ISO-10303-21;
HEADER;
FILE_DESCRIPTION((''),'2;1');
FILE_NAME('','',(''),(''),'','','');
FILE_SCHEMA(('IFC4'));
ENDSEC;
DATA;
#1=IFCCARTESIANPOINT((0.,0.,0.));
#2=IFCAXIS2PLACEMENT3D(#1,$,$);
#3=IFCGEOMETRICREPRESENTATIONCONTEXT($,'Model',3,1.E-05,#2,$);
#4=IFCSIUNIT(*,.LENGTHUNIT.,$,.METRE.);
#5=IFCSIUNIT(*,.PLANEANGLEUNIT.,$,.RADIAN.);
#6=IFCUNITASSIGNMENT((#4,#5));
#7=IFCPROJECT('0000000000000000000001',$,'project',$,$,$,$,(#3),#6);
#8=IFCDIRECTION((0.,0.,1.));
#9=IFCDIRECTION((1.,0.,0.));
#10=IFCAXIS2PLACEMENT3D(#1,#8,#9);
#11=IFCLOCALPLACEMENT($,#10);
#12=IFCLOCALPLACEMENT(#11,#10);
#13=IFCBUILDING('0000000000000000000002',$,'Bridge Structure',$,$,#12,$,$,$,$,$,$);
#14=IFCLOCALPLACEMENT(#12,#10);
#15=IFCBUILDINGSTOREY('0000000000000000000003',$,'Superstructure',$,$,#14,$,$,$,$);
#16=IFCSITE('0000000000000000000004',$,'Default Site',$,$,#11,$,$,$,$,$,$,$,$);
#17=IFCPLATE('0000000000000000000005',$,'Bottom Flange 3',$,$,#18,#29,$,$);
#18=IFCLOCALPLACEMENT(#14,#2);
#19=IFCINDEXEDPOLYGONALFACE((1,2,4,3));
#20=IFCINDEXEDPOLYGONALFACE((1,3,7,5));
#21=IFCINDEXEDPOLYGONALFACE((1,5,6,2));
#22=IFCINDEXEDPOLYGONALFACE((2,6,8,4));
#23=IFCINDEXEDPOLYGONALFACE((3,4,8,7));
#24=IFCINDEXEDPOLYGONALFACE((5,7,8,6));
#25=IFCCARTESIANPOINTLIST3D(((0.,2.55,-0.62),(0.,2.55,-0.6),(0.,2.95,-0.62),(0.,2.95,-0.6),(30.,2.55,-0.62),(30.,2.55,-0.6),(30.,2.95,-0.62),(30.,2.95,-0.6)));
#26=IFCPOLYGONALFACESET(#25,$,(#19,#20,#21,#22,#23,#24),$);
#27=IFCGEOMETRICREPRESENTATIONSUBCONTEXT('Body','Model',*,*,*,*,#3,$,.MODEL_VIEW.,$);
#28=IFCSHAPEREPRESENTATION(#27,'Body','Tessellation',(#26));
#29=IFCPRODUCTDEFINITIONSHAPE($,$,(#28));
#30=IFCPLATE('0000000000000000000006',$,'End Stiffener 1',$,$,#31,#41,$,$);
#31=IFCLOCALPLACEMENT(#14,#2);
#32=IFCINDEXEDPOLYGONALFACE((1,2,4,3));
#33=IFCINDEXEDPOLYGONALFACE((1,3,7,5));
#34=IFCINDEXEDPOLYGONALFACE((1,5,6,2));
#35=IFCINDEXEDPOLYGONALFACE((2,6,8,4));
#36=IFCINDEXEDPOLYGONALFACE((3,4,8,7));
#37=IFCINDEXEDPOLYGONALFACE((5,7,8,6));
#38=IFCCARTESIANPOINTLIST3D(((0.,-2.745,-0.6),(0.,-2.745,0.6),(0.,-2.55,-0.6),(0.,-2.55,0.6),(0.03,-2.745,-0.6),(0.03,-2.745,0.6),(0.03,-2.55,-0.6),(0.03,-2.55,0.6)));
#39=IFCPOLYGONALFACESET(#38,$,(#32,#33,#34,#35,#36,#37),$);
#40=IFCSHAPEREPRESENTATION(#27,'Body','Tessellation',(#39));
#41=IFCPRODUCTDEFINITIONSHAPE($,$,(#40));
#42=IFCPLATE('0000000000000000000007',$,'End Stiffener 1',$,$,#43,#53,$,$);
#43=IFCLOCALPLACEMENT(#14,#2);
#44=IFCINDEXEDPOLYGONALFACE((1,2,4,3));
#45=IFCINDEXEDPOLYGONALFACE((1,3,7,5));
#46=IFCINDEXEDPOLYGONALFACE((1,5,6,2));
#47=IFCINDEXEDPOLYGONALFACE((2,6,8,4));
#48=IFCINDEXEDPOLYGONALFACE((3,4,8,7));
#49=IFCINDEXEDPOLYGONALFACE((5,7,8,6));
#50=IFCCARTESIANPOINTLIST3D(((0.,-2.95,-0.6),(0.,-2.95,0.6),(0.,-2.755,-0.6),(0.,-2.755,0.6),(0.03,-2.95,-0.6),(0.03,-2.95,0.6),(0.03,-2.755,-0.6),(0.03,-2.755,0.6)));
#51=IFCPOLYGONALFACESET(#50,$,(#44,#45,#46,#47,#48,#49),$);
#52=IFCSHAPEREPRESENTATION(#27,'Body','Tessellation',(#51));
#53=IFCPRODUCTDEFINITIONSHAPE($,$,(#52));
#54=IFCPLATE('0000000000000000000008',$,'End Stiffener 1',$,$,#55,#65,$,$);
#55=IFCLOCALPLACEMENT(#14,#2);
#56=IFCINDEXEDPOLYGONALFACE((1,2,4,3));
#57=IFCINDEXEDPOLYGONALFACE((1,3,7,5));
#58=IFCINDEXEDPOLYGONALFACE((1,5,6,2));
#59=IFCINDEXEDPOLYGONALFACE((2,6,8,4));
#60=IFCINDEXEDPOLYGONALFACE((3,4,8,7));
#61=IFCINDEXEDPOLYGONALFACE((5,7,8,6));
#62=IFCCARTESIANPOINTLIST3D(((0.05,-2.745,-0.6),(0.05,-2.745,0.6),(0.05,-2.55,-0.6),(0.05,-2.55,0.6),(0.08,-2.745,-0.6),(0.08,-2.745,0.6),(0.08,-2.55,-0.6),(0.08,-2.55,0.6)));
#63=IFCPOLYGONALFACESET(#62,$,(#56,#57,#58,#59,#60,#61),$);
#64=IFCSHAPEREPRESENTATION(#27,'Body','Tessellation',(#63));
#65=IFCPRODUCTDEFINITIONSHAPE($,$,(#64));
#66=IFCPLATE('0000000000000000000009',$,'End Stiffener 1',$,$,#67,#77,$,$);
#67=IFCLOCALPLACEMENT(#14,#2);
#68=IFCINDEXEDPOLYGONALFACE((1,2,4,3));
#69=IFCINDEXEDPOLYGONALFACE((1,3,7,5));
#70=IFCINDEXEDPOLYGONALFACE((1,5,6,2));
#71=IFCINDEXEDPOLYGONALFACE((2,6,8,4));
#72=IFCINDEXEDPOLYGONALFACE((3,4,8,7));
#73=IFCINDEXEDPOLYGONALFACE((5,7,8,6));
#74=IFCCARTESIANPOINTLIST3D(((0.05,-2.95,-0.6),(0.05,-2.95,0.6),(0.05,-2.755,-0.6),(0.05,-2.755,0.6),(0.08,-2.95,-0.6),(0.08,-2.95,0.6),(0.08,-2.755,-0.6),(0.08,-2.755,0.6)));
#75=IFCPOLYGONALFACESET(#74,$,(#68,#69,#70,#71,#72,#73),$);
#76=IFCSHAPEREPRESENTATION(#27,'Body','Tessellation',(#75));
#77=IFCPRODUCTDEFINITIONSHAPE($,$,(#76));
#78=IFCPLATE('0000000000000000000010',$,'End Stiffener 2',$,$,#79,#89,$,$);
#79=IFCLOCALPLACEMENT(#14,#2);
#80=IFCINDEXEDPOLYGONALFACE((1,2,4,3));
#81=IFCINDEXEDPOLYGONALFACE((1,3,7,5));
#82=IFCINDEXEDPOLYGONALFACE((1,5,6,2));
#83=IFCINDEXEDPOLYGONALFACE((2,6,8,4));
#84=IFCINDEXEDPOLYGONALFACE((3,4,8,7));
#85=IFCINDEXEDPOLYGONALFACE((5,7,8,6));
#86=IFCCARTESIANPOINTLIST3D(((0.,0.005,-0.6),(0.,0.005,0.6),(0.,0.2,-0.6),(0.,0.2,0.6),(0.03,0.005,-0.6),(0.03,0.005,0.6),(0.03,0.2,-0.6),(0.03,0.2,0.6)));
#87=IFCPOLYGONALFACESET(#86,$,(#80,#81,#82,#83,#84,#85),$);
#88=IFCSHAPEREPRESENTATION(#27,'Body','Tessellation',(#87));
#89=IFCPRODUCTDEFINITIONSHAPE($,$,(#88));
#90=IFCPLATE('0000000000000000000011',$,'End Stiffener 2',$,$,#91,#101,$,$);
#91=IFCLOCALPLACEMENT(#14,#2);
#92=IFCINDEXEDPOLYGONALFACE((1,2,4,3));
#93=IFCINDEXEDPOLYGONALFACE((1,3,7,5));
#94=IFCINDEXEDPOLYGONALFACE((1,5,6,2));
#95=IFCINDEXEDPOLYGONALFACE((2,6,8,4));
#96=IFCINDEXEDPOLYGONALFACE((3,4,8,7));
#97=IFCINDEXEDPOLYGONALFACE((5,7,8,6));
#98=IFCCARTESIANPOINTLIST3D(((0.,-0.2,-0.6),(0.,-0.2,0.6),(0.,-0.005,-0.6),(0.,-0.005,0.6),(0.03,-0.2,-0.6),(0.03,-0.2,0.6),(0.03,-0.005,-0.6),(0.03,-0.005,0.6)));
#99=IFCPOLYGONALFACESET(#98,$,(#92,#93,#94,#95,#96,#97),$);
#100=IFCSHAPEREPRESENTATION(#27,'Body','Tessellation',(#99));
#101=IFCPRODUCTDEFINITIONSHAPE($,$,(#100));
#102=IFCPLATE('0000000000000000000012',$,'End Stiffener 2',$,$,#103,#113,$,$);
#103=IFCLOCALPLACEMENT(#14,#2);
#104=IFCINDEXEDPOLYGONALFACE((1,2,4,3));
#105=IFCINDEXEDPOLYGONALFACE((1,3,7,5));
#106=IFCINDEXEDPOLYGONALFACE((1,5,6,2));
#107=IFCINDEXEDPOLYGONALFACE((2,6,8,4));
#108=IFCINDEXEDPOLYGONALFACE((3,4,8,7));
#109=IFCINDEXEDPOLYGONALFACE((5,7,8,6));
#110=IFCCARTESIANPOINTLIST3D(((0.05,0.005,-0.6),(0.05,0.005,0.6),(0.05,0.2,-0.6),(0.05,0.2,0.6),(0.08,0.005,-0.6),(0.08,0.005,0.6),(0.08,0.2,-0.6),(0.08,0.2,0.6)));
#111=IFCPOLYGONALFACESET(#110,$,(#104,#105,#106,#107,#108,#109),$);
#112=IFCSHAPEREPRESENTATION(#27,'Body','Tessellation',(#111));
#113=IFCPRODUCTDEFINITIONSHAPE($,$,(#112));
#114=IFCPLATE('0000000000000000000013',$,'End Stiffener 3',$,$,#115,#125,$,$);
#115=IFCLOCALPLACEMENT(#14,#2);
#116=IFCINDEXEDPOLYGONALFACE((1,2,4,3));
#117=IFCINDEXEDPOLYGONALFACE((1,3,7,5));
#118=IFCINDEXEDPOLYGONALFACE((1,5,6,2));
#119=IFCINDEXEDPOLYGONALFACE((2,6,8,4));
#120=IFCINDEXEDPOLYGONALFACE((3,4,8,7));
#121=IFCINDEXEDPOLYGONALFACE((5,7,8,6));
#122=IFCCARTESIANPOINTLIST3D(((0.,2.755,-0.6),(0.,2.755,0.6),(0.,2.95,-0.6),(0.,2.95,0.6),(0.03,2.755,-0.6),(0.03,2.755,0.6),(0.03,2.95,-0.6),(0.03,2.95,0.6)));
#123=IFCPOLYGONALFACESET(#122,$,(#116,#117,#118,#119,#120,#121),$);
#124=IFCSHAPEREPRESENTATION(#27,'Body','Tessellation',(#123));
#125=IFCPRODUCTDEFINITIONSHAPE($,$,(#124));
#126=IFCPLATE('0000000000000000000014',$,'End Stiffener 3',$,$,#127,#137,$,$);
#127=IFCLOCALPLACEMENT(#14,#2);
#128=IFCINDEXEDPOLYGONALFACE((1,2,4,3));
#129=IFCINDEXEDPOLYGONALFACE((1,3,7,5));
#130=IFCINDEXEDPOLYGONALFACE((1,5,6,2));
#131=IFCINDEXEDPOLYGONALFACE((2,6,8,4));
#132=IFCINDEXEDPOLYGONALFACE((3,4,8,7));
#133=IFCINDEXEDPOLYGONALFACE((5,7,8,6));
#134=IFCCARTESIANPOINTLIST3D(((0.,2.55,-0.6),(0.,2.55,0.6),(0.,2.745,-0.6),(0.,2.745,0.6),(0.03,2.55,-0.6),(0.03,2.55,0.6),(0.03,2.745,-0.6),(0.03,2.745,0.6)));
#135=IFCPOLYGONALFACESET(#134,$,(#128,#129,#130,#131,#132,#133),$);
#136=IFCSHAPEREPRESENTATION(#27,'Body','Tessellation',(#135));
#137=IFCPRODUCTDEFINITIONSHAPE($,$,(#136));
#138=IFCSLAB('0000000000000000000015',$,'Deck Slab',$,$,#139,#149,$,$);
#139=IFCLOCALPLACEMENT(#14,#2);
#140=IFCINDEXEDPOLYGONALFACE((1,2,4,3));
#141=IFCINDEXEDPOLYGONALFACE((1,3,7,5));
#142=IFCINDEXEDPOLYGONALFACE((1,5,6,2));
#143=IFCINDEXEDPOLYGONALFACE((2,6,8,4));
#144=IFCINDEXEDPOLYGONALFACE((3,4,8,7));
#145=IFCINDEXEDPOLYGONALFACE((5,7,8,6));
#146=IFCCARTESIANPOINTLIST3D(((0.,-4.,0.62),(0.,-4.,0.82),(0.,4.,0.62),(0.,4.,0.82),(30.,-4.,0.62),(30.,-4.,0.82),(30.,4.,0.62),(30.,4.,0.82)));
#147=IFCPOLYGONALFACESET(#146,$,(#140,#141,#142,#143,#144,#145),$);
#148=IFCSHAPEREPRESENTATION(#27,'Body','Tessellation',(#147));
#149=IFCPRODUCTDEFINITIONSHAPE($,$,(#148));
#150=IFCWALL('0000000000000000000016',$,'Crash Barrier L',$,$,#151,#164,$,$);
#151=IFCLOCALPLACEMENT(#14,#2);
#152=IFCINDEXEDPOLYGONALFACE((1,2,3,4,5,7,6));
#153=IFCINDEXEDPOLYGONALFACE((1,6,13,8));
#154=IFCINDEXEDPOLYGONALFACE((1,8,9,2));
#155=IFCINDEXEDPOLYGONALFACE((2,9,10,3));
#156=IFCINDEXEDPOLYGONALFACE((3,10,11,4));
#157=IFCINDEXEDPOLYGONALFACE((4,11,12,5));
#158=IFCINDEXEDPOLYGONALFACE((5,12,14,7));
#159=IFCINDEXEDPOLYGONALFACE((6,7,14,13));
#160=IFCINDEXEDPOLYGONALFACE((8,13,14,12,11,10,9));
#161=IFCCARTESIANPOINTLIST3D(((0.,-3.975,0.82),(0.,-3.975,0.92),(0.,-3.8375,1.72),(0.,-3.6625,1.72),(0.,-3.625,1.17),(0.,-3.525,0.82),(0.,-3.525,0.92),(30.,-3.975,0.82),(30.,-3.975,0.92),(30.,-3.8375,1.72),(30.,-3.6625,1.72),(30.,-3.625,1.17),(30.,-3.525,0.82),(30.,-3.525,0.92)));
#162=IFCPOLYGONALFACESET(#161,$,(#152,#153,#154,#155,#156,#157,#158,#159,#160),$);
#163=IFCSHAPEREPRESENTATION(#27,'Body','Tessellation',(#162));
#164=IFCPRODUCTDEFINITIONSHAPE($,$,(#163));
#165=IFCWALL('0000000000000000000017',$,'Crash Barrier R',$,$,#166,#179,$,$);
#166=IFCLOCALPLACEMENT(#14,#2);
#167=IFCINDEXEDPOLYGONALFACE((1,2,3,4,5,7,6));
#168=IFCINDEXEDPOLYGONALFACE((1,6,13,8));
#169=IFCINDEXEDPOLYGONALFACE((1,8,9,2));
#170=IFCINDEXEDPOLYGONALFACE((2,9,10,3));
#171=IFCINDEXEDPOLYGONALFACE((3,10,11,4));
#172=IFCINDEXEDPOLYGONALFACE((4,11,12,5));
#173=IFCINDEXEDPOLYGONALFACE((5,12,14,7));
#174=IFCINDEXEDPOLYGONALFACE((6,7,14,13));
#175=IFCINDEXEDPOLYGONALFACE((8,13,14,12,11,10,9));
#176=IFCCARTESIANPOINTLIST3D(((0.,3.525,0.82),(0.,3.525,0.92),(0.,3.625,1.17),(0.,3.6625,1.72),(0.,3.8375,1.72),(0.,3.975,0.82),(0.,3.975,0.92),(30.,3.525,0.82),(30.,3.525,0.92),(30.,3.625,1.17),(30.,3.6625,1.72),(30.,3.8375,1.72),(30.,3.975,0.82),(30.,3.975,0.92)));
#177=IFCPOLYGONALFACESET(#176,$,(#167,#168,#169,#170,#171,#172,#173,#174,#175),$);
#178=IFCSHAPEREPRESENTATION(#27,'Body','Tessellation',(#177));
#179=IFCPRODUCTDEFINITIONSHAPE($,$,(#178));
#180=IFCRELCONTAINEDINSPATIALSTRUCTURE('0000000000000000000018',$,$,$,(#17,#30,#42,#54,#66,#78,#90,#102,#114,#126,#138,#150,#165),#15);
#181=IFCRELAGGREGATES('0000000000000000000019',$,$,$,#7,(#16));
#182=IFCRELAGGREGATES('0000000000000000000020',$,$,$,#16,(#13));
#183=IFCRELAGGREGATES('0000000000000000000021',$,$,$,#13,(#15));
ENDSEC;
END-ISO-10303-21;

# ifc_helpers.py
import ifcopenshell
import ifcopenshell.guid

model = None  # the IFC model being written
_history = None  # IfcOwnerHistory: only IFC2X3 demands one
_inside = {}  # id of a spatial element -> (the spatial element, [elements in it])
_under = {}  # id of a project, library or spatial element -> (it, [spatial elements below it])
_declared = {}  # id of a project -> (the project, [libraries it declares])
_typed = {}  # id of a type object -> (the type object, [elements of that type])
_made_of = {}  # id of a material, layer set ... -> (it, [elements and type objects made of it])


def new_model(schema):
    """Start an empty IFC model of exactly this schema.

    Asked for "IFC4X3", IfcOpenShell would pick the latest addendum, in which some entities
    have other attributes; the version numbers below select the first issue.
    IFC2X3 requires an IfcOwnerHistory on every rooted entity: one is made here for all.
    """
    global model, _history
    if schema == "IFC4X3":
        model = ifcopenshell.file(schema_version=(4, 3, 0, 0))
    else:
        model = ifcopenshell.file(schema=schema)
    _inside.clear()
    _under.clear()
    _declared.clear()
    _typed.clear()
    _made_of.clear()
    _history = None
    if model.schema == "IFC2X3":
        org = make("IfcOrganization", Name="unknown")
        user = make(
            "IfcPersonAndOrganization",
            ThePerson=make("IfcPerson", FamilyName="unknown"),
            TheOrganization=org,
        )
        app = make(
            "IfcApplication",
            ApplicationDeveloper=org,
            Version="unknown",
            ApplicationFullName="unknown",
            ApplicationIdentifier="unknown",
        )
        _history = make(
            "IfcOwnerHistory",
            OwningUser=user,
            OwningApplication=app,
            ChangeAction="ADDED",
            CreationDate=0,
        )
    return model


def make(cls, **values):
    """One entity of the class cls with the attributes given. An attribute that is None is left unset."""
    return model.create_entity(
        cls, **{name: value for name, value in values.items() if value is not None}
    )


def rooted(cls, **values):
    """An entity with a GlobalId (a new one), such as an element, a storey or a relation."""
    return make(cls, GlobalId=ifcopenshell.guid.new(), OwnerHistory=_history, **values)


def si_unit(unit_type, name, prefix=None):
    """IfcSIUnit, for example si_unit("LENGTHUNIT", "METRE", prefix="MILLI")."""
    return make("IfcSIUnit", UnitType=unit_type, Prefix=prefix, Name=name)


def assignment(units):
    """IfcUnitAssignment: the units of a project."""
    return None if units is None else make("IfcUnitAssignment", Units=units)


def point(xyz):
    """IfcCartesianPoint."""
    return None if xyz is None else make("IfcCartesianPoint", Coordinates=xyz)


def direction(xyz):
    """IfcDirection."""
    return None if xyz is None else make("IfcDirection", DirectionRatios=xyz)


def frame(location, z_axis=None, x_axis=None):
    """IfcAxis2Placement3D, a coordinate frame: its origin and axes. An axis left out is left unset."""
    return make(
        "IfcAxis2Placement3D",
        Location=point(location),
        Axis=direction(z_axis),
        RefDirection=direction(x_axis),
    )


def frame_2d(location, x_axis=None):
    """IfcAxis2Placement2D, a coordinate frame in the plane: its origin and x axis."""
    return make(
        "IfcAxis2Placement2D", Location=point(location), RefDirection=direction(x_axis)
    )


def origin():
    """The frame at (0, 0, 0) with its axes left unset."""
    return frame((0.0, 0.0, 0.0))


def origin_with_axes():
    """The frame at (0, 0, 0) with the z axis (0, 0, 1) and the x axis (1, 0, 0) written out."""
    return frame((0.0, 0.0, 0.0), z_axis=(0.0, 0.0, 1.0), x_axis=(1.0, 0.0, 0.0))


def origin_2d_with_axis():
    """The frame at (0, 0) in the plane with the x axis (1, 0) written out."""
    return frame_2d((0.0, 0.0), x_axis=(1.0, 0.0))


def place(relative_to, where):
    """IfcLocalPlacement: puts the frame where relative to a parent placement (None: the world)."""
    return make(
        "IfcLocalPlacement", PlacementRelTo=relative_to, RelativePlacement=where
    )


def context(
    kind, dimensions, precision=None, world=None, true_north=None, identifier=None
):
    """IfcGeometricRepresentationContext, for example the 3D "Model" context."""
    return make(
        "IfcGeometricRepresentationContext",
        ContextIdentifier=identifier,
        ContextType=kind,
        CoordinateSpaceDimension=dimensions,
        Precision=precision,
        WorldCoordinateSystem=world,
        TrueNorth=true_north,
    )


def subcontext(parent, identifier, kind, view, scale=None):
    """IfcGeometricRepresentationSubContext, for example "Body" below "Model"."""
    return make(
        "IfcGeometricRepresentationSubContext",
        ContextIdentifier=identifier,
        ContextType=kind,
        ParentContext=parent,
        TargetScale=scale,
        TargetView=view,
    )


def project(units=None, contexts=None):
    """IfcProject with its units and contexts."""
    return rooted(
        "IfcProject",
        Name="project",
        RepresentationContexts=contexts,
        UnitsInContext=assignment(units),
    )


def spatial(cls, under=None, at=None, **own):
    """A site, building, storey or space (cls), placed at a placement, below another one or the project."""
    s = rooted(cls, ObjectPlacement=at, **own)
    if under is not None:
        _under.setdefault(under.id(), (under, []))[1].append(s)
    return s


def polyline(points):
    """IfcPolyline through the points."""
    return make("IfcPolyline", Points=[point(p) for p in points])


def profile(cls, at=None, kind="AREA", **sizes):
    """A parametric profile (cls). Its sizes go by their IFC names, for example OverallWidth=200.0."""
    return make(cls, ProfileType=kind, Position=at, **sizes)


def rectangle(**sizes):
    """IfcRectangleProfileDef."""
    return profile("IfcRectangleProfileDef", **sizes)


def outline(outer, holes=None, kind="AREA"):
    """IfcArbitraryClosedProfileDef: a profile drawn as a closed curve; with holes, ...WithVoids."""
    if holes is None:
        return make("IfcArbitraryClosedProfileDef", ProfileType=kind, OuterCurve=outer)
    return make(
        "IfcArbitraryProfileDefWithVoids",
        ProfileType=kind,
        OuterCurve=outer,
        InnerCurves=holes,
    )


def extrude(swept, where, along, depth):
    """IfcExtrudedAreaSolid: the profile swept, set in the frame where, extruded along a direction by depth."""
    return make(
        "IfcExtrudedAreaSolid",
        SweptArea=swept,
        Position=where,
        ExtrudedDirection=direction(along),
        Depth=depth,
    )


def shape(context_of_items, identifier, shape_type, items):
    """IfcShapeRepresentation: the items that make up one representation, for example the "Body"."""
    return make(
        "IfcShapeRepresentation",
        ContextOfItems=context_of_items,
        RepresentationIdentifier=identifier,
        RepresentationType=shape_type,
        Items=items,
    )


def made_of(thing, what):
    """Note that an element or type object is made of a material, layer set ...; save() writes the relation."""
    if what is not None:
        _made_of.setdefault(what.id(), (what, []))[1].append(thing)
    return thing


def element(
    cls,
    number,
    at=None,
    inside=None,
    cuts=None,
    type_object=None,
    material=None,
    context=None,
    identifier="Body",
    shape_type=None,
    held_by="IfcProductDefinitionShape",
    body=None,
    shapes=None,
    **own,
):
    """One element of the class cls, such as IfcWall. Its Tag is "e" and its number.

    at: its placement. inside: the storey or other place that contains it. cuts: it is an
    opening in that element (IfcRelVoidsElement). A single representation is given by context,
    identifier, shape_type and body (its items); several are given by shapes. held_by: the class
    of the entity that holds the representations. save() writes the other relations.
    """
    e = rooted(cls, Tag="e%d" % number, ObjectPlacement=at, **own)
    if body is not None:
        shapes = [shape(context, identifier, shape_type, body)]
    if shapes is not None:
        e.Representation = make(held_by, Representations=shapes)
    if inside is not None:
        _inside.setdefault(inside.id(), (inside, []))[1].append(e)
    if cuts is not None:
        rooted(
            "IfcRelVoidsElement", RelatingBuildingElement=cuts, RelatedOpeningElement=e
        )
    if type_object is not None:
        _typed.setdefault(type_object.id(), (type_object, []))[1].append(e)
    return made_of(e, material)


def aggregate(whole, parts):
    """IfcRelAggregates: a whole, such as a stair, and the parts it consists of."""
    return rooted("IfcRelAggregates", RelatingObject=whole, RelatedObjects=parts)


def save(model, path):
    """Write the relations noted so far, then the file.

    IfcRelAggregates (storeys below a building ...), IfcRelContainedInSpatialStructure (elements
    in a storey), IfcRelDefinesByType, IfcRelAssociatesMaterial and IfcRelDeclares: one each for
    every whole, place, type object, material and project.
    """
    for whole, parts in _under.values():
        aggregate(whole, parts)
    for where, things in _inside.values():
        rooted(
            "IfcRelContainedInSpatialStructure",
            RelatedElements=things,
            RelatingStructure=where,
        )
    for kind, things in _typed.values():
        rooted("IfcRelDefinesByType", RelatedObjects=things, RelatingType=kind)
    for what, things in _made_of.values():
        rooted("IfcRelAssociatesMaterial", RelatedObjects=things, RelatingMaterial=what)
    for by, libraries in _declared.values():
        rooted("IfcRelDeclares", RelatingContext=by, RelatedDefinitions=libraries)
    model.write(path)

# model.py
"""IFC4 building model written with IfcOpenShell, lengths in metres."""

from ifc_helpers import new_model, si_unit, frame, origin, origin_with_axes, origin_2d_with_axis, place, context, subcontext, project, spatial, polyline, rectangle, outline, extrude, element, save


model = new_model("IFC4")

# Units and contexts
model_context = context("Model", 3, precision=1e-05, world=origin())
body_context = subcontext(model_context, "Body", "Model", "MODEL_VIEW")
ifc_project = project(units=[si_unit("LENGTHUNIT", "METRE"), si_unit("PLANEANGLEUNIT", "RADIAN")], contexts=[model_context])

# Site, building, storey
site_placement = place(None, origin_with_axes())
site = spatial("IfcSite", under=ifc_project, at=site_placement, Name="Default Site")
building_placement = place(site_placement, origin_with_axes())
building = spatial("IfcBuilding", under=site, at=building_placement, Name="Bridge Structure")
storey_placement = place(building_placement, origin_with_axes())
storey = spatial("IfcBuildingStorey", under=building, at=storey_placement, Name="Superstructure")

# Plates
for number, where, z_axis, x_axis, name in (
    (1, (0.0, 2.75, -0.61), (1.0, 0.0, 0.0), (0.0, 1.0, 0.0), "Bottom Flange 3"),
):
    element("IfcPlate", number, at=place(storey_placement, frame(where, z_axis=z_axis, x_axis=x_axis)), inside=storey, Name=name, context=body_context, shape_type="SweptSolid", body=[
        extrude(rectangle(XDim=0.4, YDim=0.02, at=origin_2d_with_axis()), origin_with_axes(), (0.0, 0.0, 1.0), 30.0),
    ])
for number, where, z_axis, x_axis, name in (
    (2, (0.015, -2.6475, -0.6), (0.0, 0.0, 1.0), (1.0, 0.0, 0.0), "End Stiffener 1"),
    (3, (0.015, -2.8525, -0.6), (0.0, 0.0, 1.0), (1.0, 0.0, 0.0), "End Stiffener 1"),
    (4, (0.065, -2.6475, -0.6), (0.0, 0.0, 1.0), (1.0, 0.0, 0.0), "End Stiffener 1"),
    (5, (0.065, -2.8525, -0.6), (0.0, 0.0, 1.0), (1.0, 0.0, 0.0), "End Stiffener 1"),
    (6, (0.015, 0.1025, -0.6), (0.0, 0.0, 1.0), (1.0, 0.0, 0.0), "End Stiffener 2"),
    (7, (0.015, -0.1025, -0.6), (0.0, 0.0, 1.0), (1.0, 0.0, 0.0), "End Stiffener 2"),
    (8, (0.065, 0.1025, -0.6), (0.0, 0.0, 1.0), (1.0, 0.0, 0.0), "End Stiffener 2"),
    (9, (0.015, 2.8525, -0.6), (0.0, 0.0, 1.0), (1.0, 0.0, 0.0), "End Stiffener 3"),
    (10, (0.015, 2.6475, -0.6), (0.0, 0.0, 1.0), (1.0, 0.0, 0.0), "End Stiffener 3"),
):
    element("IfcPlate", number, at=place(storey_placement, frame(where, z_axis=z_axis, x_axis=x_axis)), inside=storey, Name=name, context=body_context, shape_type="SweptSolid", body=[
        extrude(rectangle(XDim=0.03, YDim=0.195, at=origin_2d_with_axis()), origin_with_axes(), (0.0, 0.0, 1.0), 1.2),
    ])

# Slab
slab_placement = place(storey_placement, frame((0.0, 0.0, 0.62), z_axis=(0.0, 0.0, 1.0), x_axis=(1.0, 0.0, 0.0)))
element("IfcSlab", 11, at=slab_placement, inside=storey, Name="Deck Slab", context=body_context, shape_type="SweptSolid", body=[
    extrude(outline(polyline([(0.0, -4.0), (30.0, -4.0), (30.0, 4.0), (0.0, 4.0), (0.0, -4.0)])), origin_with_axes(), (0.0, 0.0, 1.0), 0.2),
])

# Walls
wall_1_placement = place(storey_placement, frame((0.0, -3.975, 0.82), z_axis=(1.0, 0.0, 0.0), x_axis=(0.0, 1.0, 0.0)))
element("IfcWall", 12, at=wall_1_placement, inside=storey, Name="Crash Barrier L", context=body_context, shape_type="SweptSolid", body=[
    extrude(outline(polyline([(0.0, 0.0), (0.45, 0.0), (0.45, 0.1), (0.35, 0.35), (0.3125, 0.9), (0.1375, 0.9), (0.0, 0.1), (0.0, 0.0)])), origin_with_axes(), (0.0, 0.0, 1.0), 30.0),
])
wall_2_placement = place(storey_placement, frame((0.0, 3.525, 0.82), z_axis=(1.0, 0.0, 0.0), x_axis=(0.0, 1.0, 0.0)))
element("IfcWall", 13, at=wall_2_placement, inside=storey, Name="Crash Barrier R", context=body_context, shape_type="SweptSolid", body=[
    extrude(outline(polyline([(0.45, 0.0), (0.0, 0.0), (0.0, 0.1), (0.1, 0.35), (0.1375, 0.9), (0.3125, 0.9), (0.45, 0.1), (0.45, 0.0)])), origin_with_axes(), (0.0, 0.0, 1.0), 30.0),
])

save(model, "model.ifc")
